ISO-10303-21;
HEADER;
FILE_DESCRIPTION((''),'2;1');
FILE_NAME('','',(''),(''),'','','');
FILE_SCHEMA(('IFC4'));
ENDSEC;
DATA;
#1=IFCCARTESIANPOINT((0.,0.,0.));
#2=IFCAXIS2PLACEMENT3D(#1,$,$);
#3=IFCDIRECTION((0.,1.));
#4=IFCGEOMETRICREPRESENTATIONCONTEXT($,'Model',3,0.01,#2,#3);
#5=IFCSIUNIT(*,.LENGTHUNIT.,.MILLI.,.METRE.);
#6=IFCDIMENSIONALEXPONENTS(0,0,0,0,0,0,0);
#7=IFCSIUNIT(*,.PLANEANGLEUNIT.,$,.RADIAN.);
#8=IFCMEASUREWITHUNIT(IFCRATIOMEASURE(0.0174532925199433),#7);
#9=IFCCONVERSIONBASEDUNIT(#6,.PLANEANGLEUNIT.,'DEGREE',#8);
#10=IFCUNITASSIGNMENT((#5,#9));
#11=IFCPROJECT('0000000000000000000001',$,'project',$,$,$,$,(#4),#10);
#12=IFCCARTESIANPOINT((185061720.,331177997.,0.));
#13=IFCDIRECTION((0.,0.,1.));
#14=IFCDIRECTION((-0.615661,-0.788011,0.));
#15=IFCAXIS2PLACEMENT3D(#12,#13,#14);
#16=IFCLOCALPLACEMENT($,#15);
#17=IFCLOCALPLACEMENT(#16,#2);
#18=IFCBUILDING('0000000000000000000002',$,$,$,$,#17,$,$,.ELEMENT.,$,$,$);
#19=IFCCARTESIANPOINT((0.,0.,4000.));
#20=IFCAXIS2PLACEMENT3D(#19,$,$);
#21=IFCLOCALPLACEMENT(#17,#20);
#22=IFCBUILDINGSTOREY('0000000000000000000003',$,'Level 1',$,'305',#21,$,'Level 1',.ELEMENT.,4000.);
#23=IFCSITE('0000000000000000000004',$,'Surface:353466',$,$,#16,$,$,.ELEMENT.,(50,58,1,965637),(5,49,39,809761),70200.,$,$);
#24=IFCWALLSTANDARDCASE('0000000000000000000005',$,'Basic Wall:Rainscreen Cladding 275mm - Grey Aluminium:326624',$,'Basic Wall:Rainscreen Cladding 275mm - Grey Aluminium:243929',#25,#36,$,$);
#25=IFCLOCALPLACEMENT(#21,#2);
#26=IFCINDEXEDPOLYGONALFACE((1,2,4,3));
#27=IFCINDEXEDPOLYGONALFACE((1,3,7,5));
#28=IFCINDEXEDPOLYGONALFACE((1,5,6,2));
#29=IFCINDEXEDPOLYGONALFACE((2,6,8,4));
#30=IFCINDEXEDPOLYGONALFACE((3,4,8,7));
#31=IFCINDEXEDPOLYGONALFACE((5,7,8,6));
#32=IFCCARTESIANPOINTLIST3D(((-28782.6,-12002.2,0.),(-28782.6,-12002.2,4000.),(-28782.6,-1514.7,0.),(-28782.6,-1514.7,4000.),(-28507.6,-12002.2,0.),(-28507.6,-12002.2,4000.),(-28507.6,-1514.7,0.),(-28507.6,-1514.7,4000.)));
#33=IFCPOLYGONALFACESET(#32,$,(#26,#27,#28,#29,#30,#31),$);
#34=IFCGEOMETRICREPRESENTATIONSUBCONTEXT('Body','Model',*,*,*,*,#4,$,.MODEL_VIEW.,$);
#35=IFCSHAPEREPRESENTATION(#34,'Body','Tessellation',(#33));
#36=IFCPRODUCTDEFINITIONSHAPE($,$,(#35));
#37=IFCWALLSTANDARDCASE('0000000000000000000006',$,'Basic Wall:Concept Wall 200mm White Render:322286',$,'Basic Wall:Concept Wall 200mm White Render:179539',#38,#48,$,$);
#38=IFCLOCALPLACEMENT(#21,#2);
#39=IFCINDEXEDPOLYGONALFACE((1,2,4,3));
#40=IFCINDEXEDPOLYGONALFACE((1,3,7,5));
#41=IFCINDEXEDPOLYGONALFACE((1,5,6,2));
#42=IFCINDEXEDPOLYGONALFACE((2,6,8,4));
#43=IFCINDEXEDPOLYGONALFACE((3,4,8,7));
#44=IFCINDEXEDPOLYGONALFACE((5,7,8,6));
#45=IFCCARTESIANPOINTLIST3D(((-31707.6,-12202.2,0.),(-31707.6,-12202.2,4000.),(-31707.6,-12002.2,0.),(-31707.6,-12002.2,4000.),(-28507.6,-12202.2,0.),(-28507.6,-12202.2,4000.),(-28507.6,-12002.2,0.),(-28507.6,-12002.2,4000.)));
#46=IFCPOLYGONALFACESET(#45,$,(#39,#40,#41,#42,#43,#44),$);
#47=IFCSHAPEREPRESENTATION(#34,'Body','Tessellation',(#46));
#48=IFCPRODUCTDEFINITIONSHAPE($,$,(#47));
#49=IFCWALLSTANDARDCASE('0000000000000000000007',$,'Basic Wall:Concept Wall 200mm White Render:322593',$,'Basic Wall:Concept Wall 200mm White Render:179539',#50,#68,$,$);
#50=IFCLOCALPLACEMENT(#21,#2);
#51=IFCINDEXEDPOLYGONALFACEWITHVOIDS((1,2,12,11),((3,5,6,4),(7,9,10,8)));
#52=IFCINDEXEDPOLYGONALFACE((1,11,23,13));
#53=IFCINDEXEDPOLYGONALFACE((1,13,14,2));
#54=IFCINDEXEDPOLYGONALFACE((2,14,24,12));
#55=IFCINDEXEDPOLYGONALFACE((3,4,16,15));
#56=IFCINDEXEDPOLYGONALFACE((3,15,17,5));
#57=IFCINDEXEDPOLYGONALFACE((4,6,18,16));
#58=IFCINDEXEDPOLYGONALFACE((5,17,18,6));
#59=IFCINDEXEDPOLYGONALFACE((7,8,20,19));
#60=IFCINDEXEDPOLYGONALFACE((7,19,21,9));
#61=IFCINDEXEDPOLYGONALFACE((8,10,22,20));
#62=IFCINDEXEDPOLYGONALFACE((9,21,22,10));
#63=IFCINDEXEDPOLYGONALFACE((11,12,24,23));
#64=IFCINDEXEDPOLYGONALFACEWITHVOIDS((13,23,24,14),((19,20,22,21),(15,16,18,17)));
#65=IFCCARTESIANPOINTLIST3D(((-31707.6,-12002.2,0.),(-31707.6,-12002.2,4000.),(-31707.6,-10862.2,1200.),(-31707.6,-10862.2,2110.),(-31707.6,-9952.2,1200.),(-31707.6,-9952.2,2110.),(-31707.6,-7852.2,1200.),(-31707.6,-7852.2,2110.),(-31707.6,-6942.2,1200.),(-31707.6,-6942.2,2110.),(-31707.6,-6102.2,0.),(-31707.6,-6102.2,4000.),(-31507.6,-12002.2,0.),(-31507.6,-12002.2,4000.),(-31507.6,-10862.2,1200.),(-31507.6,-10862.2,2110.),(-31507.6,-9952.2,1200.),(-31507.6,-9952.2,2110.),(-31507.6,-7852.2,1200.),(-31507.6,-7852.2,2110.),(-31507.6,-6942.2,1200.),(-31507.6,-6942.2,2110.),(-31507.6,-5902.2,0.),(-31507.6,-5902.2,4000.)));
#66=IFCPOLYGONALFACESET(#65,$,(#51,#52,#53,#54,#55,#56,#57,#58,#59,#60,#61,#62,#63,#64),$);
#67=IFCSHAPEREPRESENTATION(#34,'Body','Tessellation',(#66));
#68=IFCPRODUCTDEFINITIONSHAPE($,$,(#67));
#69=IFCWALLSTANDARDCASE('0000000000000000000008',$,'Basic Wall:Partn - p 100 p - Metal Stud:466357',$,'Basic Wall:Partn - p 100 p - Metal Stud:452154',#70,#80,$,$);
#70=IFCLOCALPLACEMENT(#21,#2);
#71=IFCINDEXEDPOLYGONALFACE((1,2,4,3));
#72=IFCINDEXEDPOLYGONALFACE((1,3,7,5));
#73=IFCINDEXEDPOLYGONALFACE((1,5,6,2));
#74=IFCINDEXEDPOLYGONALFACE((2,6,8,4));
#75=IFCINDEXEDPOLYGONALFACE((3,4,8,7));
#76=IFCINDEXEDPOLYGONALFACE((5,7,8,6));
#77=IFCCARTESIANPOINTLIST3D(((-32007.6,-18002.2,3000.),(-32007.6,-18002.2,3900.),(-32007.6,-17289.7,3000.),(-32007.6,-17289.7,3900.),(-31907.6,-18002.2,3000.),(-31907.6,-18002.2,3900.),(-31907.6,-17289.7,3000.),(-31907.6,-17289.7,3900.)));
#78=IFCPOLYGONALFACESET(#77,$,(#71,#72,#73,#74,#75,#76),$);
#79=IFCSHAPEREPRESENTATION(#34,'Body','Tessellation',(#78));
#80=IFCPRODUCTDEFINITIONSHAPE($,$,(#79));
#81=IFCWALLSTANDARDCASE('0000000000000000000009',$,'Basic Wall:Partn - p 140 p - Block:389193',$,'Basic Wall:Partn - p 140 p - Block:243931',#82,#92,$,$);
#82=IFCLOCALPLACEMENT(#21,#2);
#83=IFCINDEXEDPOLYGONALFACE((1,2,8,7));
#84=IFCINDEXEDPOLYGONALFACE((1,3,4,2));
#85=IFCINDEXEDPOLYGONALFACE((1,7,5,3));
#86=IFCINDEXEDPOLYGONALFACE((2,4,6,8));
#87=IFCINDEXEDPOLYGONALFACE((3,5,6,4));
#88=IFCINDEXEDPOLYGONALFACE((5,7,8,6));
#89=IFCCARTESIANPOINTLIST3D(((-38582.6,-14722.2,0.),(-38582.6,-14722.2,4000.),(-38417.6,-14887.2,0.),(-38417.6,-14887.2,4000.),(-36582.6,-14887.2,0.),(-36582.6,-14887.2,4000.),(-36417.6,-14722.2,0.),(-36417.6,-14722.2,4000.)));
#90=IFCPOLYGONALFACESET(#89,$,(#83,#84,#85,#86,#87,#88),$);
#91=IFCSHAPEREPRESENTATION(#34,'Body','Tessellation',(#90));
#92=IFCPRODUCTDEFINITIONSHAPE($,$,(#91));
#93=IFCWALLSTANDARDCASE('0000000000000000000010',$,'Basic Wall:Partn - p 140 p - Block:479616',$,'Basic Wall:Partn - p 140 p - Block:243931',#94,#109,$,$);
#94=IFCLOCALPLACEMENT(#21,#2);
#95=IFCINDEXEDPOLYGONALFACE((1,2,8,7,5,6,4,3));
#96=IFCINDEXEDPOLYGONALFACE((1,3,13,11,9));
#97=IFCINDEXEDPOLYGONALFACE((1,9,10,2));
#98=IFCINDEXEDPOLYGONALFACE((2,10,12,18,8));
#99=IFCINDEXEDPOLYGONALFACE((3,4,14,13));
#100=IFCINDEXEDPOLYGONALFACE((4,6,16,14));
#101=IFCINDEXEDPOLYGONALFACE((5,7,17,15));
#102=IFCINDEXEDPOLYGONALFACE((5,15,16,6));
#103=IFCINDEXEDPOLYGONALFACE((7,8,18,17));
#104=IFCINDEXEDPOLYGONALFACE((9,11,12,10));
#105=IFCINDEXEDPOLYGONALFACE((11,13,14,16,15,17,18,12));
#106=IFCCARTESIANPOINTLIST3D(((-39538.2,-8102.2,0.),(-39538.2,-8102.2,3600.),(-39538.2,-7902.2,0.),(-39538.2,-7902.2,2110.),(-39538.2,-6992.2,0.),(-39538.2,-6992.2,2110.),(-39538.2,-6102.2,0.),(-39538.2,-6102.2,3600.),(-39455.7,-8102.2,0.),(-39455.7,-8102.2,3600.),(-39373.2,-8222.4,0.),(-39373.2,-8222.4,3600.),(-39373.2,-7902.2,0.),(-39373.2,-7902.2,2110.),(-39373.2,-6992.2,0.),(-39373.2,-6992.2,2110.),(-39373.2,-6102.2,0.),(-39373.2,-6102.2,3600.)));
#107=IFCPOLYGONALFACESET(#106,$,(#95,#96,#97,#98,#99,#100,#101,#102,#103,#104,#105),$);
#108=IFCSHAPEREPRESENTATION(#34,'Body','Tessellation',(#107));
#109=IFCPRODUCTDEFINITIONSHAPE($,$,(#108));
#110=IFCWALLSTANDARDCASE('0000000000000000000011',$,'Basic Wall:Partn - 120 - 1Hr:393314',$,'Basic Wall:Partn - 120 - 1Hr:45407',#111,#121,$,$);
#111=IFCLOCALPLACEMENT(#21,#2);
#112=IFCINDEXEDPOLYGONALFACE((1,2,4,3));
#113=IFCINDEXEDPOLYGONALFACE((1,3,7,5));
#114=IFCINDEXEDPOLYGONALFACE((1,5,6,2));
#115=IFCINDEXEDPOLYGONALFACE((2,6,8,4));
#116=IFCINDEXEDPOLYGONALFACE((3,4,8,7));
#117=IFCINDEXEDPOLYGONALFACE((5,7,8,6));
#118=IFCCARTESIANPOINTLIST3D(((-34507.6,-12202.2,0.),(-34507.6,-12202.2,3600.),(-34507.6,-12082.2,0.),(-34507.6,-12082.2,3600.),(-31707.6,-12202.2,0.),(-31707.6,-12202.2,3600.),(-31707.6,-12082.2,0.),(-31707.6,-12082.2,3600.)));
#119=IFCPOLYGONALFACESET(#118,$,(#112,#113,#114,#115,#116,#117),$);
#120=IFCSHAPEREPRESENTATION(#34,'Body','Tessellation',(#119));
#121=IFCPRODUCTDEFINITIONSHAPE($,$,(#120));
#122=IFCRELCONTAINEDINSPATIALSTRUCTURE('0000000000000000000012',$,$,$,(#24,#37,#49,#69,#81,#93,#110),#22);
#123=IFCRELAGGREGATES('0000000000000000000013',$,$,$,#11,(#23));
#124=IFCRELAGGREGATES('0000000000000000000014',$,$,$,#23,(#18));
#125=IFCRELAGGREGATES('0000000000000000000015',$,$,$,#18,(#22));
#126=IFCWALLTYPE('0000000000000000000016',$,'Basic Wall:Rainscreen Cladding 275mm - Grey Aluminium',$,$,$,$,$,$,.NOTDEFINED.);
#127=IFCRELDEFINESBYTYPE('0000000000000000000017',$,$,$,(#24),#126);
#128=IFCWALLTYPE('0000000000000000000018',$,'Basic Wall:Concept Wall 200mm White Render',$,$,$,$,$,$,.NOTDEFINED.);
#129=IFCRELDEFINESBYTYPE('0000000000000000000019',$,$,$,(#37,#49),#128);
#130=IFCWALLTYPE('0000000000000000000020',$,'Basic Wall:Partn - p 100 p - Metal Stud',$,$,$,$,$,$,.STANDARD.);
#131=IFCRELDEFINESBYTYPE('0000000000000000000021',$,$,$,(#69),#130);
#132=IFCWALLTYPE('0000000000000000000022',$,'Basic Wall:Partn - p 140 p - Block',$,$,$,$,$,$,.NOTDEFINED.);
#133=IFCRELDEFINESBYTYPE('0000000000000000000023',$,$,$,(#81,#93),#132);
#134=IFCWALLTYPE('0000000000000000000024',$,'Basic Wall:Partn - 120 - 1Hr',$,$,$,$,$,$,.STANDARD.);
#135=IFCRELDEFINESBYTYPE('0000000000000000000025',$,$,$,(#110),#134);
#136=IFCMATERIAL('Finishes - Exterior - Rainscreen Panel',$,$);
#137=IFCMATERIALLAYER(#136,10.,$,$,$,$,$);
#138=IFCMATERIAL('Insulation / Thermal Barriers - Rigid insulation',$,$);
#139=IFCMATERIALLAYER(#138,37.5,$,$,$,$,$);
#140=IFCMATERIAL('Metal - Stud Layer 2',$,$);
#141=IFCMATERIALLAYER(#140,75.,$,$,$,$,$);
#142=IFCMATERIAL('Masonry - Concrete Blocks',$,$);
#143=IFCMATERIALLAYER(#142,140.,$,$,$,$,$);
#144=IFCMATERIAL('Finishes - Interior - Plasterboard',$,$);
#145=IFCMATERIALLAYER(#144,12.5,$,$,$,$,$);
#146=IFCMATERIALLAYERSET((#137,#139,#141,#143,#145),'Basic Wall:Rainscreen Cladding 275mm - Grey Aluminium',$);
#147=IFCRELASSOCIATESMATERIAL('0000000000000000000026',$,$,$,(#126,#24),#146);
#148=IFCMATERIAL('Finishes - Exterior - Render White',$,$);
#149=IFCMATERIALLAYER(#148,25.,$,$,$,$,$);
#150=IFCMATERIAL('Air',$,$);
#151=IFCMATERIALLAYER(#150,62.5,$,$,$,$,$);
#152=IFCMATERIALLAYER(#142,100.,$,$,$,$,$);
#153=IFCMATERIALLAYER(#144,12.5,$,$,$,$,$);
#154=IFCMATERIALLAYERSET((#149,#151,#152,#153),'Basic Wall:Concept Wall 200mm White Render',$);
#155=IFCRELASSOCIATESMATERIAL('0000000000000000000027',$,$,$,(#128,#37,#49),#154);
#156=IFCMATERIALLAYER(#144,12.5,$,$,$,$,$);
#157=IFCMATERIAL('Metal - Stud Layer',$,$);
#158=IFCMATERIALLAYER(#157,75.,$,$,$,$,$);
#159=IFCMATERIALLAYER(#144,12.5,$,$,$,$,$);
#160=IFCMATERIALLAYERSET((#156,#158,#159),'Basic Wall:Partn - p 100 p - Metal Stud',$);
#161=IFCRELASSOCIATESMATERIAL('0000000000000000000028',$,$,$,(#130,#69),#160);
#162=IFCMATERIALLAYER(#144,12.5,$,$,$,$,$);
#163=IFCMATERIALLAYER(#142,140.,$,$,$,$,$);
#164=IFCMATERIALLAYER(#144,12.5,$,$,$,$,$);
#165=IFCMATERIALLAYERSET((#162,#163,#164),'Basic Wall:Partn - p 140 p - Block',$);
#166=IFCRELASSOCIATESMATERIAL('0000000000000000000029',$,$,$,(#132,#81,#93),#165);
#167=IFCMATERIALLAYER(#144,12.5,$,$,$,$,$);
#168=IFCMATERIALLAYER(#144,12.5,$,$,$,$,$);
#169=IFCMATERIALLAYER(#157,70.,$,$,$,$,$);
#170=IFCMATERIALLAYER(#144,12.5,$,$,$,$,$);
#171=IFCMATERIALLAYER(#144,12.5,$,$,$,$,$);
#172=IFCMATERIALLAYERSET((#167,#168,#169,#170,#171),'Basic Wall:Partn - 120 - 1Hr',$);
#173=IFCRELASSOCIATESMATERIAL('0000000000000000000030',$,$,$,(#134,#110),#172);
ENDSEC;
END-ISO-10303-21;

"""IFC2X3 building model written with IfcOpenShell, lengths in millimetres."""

from ifc_helpers import new_model, entity, si_unit, converted_unit, direction, frame, frame_2d, origin, place, context, subcontext, project, spatial, polyline, rectangle, outline, extrude, clip, halfspace, bounded_halfspace, material, layer, layer_set, layer_usage, type_object, element, save


model = new_model("IFC2X3")

# Units and contexts
model_context = context("Model", 3, precision=0.01, world=origin(), true_north=direction((0.0, 1.0)))
body_context = subcontext(model_context, "Body", "Model", "MODEL_VIEW")
ifc_project = project(units=[si_unit("LENGTHUNIT", "METRE", prefix="MILLI"), converted_unit("PLANEANGLEUNIT", "DEGREE", entity("IfcRatioMeasure", 0.0174532925199433), si_unit("PLANEANGLEUNIT", "RADIAN"), dimensions=[0, 0, 0, 0, 0, 0, 0])], contexts=[model_context])

# Site, building, storey
site_placement = place(None, frame((185061720.0, 331177997.0, 0.0), z_axis=(0.0, 0.0, 1.0), x_axis=(-0.615661, -0.788011, 0.0)))
site = spatial("IfcSite", under=ifc_project, at=site_placement, Name="Surface:353466", CompositionType="ELEMENT", RefLatitude=(50, 58, 1, 965637), RefLongitude=(5, 49, 39, 809761), RefElevation=70200.0)
building_placement = place(site_placement, origin())
building = spatial("IfcBuilding", under=site, at=building_placement, CompositionType="ELEMENT")
storey_placement = place(building_placement, frame((0.0, 0.0, 4000.0)))
storey = spatial("IfcBuildingStorey", under=building, at=storey_placement, Name="Level 1", ObjectType="305", LongName="Level 1", CompositionType="ELEMENT", Elevation=4000.0)

# Walls
ifc_material_1 = material(Name="Finishes - Exterior - Rainscreen Panel")
ifc_layer_1 = layer(ifc_material_1, 10.0)
ifc_material_2 = material(Name="Insulation / Thermal Barriers - Rigid insulation")
ifc_layer_2 = layer(ifc_material_2, 37.5)
ifc_material_3 = material(Name="Metal - Stud Layer 2")
ifc_layer_3 = layer(ifc_material_3, 75.0)
ifc_material_4 = material(Name="Masonry - Concrete Blocks")
ifc_layer_4 = layer(ifc_material_4, 140.0)
ifc_material_5 = material(Name="Finishes - Interior - Plasterboard")
ifc_layer_5 = layer(ifc_material_5, 12.5)
ifc_layer_set_1 = layer_set([ifc_layer_1, ifc_layer_2, ifc_layer_3, ifc_layer_4, ifc_layer_5], Name="Basic Wall:Rainscreen Cladding 275mm - Grey Aluminium")
ifc_layer_usage_1 = layer_usage(ifc_layer_set_1, "AXIS2", "NEGATIVE", 137.5)
wall_type_1 = type_object("IfcWallType", Name="Basic Wall:Rainscreen Cladding 275mm - Grey Aluminium", PredefinedType="NOTDEFINED", material=ifc_layer_set_1)
wall_1_placement = place(storey_placement, frame((-28645.1, -12002.2, 0.0), z_axis=(0.0, 0.0, 1.0), x_axis=(0.0, 1.0, 0.0)))
element("IfcWallStandardCase", 1, at=wall_1_placement, inside=storey, type_object=wall_type_1, material=ifc_layer_usage_1, Name="Basic Wall:Rainscreen Cladding 275mm - Grey Aluminium:326624", ObjectType="Basic Wall:Rainscreen Cladding 275mm - Grey Aluminium:243929", context=body_context, shape_type="Clipping", body=[
    clip(extrude(rectangle(XDim=10487.5, YDim=275.0, at=frame_2d((5243.7, 0.0), x_axis=(-1.0, 0.0))), origin(), (0.0, 0.0, 1.0), 4000.0), halfspace(frame((0.0, 0.0, -4000.0)), True)),
])
ifc_material_6 = material(Name="Finishes - Exterior - Render White")
ifc_layer_6 = layer(ifc_material_6, 25.0)
ifc_material_7 = material(Name="Air")
ifc_layer_7 = layer(ifc_material_7, 62.5)
ifc_layer_8 = layer(ifc_material_4, 100.0)
ifc_layer_9 = layer(ifc_material_5, 12.5)
ifc_layer_set_2 = layer_set([ifc_layer_6, ifc_layer_7, ifc_layer_8, ifc_layer_9], Name="Basic Wall:Concept Wall 200mm White Render")
ifc_layer_usage_2 = layer_usage(ifc_layer_set_2, "AXIS2", "POSITIVE", -100.0)
wall_type_2 = type_object("IfcWallType", Name="Basic Wall:Concept Wall 200mm White Render", PredefinedType="NOTDEFINED", material=ifc_layer_set_2)
wall_2_placement = place(storey_placement, frame((-28507.6, -12102.2, 0.0), z_axis=(0.0, 0.0, 1.0), x_axis=(-1.0, 0.0, 0.0)))
element("IfcWallStandardCase", 2, at=wall_2_placement, inside=storey, type_object=wall_type_2, material=ifc_layer_usage_2, Name="Basic Wall:Concept Wall 200mm White Render:322286", ObjectType="Basic Wall:Concept Wall 200mm White Render:179539", context=body_context, shape_type="Clipping", body=[
    clip(extrude(rectangle(XDim=3200.0, YDim=200.0, at=frame_2d((1600.0, 0.0), x_axis=(-1.0, 0.0))), origin(), (0.0, 0.0, 1.0), 4000.0), halfspace(frame((0.0, 0.0, -4000.0)), True)),
])

# Wall, openings
ifc_layer_usage_3 = layer_usage(ifc_layer_set_2, "AXIS2", "POSITIVE", -100.0)
wall_3_placement = place(storey_placement, frame((-31607.6, -12002.2, 0.0), z_axis=(0.0, 0.0, 1.0), x_axis=(0.0, 1.0, 0.0)))
wall_3 = element("IfcWallStandardCase", 3, at=wall_3_placement, inside=storey, type_object=wall_type_2, material=ifc_layer_usage_3, Name="Basic Wall:Concept Wall 200mm White Render:322593", ObjectType="Basic Wall:Concept Wall 200mm White Render:179539", context=body_context, shape_type="Clipping", body=[
    clip(extrude(outline(polyline([(6100.0, -100.0), (5900.0, 100.0), (0.0, 100.0), (0.0, -100.0), (6100.0, -100.0)])), origin(), (0.0, 0.0, 1.0), 4000.0), halfspace(frame((0.0, 0.0, -4000.0)), True)),
])
opening_1_placement = place(wall_3_placement, origin())
element("IfcOpeningElement", 4, at=opening_1_placement, cuts=wall_3, ObjectType="Opening", context=body_context, shape_type="SweptSolid", body=[
    extrude(rectangle(XDim=910.0, YDim=910.0, at=frame_2d((0.0, 0.0), x_axis=(1.0, 0.0))), frame((1595.0, -1424.0, 1655.0), z_axis=(0.0, 1.0, 0.0), x_axis=(0.0, 0.0, -1.0)), (0.0, 0.0, 1.0), 3048.0),
])
opening_2_placement = place(wall_3_placement, origin())
element("IfcOpeningElement", 5, at=opening_2_placement, cuts=wall_3, ObjectType="Opening", context=body_context, shape_type="SweptSolid", body=[
    extrude(rectangle(XDim=910.0, YDim=910.0, at=frame_2d((0.0, 0.0), x_axis=(1.0, 0.0))), frame((4605.0, -1424.0, 1655.0), z_axis=(0.0, 1.0, 0.0), x_axis=(0.0, 0.0, -1.0)), (0.0, 0.0, 1.0), 3048.0),
])
opening_3_placement = place(wall_3_placement, frame((2050.0, 100.0, 1200.0)))
element("IfcOpeningElement", 6, at=opening_3_placement, cuts=wall_3, ObjectType="Opening", context=body_context, shape_type="SweptSolid", body=[
    extrude(rectangle(XDim=910.0, YDim=910.0, at=frame_2d((455.0, 455.0), x_axis=(-1.0, 0.0))), frame((0.0, 0.0, 0.0), z_axis=(0.0, -1.0, 0.0), x_axis=(0.0, 0.0, 1.0)), (0.0, 0.0, 1.0), 200.0),
])
opening_4_placement = place(wall_3_placement, frame((5060.0, 100.0, 1200.0)))
element("IfcOpeningElement", 7, at=opening_4_placement, cuts=wall_3, ObjectType="Opening", context=body_context, shape_type="SweptSolid", body=[
    extrude(rectangle(XDim=910.0, YDim=910.0, at=frame_2d((455.0, 455.0), x_axis=(-1.0, 0.0))), frame((0.0, 0.0, 0.0), z_axis=(0.0, -1.0, 0.0), x_axis=(0.0, 0.0, 1.0)), (0.0, 0.0, 1.0), 200.0),
])

# Wall
ifc_layer_10 = layer(ifc_material_5, 12.5)
ifc_material_8 = material(Name="Metal - Stud Layer")
ifc_layer_11 = layer(ifc_material_8, 75.0)
ifc_layer_12 = layer(ifc_material_5, 12.5)
ifc_layer_set_3 = layer_set([ifc_layer_10, ifc_layer_11, ifc_layer_12], Name="Basic Wall:Partn - p 100 p - Metal Stud")
ifc_layer_usage_4 = layer_usage(ifc_layer_set_3, "AXIS2", "NEGATIVE", 50.0)
wall_type_3 = type_object("IfcWallType", Name="Basic Wall:Partn - p 100 p - Metal Stud", PredefinedType="STANDARD", material=ifc_layer_set_3)
wall_4_placement = place(storey_placement, frame((-31957.6, -17289.7, 3000.0), z_axis=(0.0, 0.0, 1.0), x_axis=(0.0, -1.0, 0.0)))
element("IfcWallStandardCase", 8, at=wall_4_placement, inside=storey, type_object=wall_type_3, material=ifc_layer_usage_4, Name="Basic Wall:Partn - p 100 p - Metal Stud:466357", ObjectType="Basic Wall:Partn - p 100 p - Metal Stud:452154", context=body_context, shape_type="SweptSolid", body=[
    extrude(rectangle(XDim=712.5, YDim=100.0, at=frame_2d((356.2, 0.0), x_axis=(-1.0, 0.0))), origin(), (0.0, 0.0, 1.0), 900.0),
])

# Shared definitions
ifc_layer_13 = layer(ifc_material_5, 12.5)
ifc_layer_14 = layer(ifc_material_4, 140.0)
ifc_layer_15 = layer(ifc_material_5, 12.5)
ifc_layer_set_4 = layer_set([ifc_layer_13, ifc_layer_14, ifc_layer_15], Name="Basic Wall:Partn - p 140 p - Block")
wall_type_4 = type_object("IfcWallType", Name="Basic Wall:Partn - p 140 p - Block", PredefinedType="NOTDEFINED", material=ifc_layer_set_4)

# Wall
ifc_layer_usage_5 = layer_usage(ifc_layer_set_4, "AXIS2", "NEGATIVE", 82.5)
wall_5_placement = place(storey_placement, frame((-38582.6, -14804.7, 0.0)))
element("IfcWallStandardCase", 9, at=wall_5_placement, inside=storey, type_object=wall_type_4, material=ifc_layer_usage_5, Name="Basic Wall:Partn - p 140 p - Block:389193", ObjectType="Basic Wall:Partn - p 140 p - Block:243931", context=body_context, shape_type="Clipping", body=[
    clip(extrude(outline(polyline([(2000.0, -82.5), (2165.0, 82.5), (0.0, 82.5), (165.0, -82.5), (2000.0, -82.5)])), origin(), (0.0, 0.0, 1.0), 4000.0), halfspace(frame((0.0, 0.0, -4000.0)), True)),
])

# Wall, openings
ifc_layer_usage_6 = layer_usage(ifc_layer_set_4, "AXIS2", "NEGATIVE", 82.5)
wall_6_placement = place(storey_placement, frame((-39455.7, -8222.4, 0.0), z_axis=(0.0, 0.0, 1.0), x_axis=(0.0, 1.0, 0.0)))
wall_6 = element("IfcWallStandardCase", 10, at=wall_6_placement, inside=storey, type_object=wall_type_4, material=ifc_layer_usage_6, Name="Basic Wall:Partn - p 140 p - Block:479616", ObjectType="Basic Wall:Partn - p 140 p - Block:243931", context=body_context, shape_type="Clipping", body=[
    clip(extrude(outline(polyline([(0.0, -82.5), (2120.1, -82.5), (2120.1, 82.5), (120.1, 82.5), (120.1, 0.0), (0.0, -82.5)])), origin(), (0.0, 0.0, 1.0), 3600.0), bounded_halfspace(frame((0.0, -82.5, 3600.0), z_axis=(0.0, 0.0, -1.0), x_axis=(0.0, -1.0, 0.0)), True, frame((0.0, -82.5, 3600.0)), polyline([(0.0, 0.0), (2120.1, 0.0), (2120.1, 165.0), (120.1, 165.0), (120.1, 82.5), (0.0, 0.0)]))),
])
opening_5_placement = place(wall_6_placement, origin())
element("IfcOpeningElement", 11, at=opening_5_placement, cuts=wall_6, ObjectType="Opening", context=body_context, shape_type="SweptSolid", body=[
    extrude(rectangle(XDim=2110.0, YDim=910.0, at=frame_2d((0.0, 0.0), x_axis=(1.0, 0.0))), frame((775.1, -1606.5, 1055.0), z_axis=(0.0, 1.0, 0.0), x_axis=(0.0, 0.0, 1.0)), (0.0, 0.0, 1.0), 3048.0),
])
opening_6_placement = place(wall_6_placement, frame((320.1, -82.5, 0.0)))
element("IfcOpeningElement", 12, at=opening_6_placement, cuts=wall_6, ObjectType="Opening", context=body_context, shape_type="SweptSolid", body=[
    extrude(rectangle(XDim=2110.0, YDim=910.0, at=frame_2d((1055.0, 455.0), x_axis=(1.0, 0.0))), frame((0.0, 0.0, 0.0), z_axis=(0.0, 1.0, 0.0), x_axis=(0.0, 0.0, 1.0)), (0.0, 0.0, 1.0), 165.0),
])

# Wall
ifc_layer_16 = layer(ifc_material_5, 12.5)
ifc_layer_17 = layer(ifc_material_5, 12.5)
ifc_layer_18 = layer(ifc_material_8, 70.0)
ifc_layer_19 = layer(ifc_material_5, 12.5)
ifc_layer_20 = layer(ifc_material_5, 12.5)
ifc_layer_set_5 = layer_set([ifc_layer_16, ifc_layer_17, ifc_layer_18, ifc_layer_19, ifc_layer_20], Name="Basic Wall:Partn - 120 - 1Hr")
ifc_layer_usage_7 = layer_usage(ifc_layer_set_5, "AXIS2", "NEGATIVE", 60.0)
wall_type_5 = type_object("IfcWallType", Name="Basic Wall:Partn - 120 - 1Hr", PredefinedType="STANDARD", material=ifc_layer_set_5)
wall_7_placement = place(storey_placement, frame((-34507.6, -12142.2, 0.0)))
element("IfcWallStandardCase", 13, at=wall_7_placement, inside=storey, type_object=wall_type_5, material=ifc_layer_usage_7, Name="Basic Wall:Partn - 120 - 1Hr:393314", ObjectType="Basic Wall:Partn - 120 - 1Hr:45407", context=body_context, shape_type="Clipping", body=[
    clip(extrude(rectangle(XDim=2800.0, YDim=120.0, at=frame_2d((1400.0, 0.0), x_axis=(-1.0, 0.0))), origin(), (0.0, 0.0, 1.0), 3600.0), bounded_halfspace(frame((0.0, -60.0, 3600.0), z_axis=(0.0, 0.0, -1.0), x_axis=(1.0, 0.0, 0.0)), True, frame((0.0, -60.0, 3600.0)), polyline([(0.0, 0.0), (2800.0, 0.0), (2800.0, 120.0), (120.0, 120.0), (0.0, 120.0), (0.0, 0.0)]))),
])

save(model, "model.ifc")
